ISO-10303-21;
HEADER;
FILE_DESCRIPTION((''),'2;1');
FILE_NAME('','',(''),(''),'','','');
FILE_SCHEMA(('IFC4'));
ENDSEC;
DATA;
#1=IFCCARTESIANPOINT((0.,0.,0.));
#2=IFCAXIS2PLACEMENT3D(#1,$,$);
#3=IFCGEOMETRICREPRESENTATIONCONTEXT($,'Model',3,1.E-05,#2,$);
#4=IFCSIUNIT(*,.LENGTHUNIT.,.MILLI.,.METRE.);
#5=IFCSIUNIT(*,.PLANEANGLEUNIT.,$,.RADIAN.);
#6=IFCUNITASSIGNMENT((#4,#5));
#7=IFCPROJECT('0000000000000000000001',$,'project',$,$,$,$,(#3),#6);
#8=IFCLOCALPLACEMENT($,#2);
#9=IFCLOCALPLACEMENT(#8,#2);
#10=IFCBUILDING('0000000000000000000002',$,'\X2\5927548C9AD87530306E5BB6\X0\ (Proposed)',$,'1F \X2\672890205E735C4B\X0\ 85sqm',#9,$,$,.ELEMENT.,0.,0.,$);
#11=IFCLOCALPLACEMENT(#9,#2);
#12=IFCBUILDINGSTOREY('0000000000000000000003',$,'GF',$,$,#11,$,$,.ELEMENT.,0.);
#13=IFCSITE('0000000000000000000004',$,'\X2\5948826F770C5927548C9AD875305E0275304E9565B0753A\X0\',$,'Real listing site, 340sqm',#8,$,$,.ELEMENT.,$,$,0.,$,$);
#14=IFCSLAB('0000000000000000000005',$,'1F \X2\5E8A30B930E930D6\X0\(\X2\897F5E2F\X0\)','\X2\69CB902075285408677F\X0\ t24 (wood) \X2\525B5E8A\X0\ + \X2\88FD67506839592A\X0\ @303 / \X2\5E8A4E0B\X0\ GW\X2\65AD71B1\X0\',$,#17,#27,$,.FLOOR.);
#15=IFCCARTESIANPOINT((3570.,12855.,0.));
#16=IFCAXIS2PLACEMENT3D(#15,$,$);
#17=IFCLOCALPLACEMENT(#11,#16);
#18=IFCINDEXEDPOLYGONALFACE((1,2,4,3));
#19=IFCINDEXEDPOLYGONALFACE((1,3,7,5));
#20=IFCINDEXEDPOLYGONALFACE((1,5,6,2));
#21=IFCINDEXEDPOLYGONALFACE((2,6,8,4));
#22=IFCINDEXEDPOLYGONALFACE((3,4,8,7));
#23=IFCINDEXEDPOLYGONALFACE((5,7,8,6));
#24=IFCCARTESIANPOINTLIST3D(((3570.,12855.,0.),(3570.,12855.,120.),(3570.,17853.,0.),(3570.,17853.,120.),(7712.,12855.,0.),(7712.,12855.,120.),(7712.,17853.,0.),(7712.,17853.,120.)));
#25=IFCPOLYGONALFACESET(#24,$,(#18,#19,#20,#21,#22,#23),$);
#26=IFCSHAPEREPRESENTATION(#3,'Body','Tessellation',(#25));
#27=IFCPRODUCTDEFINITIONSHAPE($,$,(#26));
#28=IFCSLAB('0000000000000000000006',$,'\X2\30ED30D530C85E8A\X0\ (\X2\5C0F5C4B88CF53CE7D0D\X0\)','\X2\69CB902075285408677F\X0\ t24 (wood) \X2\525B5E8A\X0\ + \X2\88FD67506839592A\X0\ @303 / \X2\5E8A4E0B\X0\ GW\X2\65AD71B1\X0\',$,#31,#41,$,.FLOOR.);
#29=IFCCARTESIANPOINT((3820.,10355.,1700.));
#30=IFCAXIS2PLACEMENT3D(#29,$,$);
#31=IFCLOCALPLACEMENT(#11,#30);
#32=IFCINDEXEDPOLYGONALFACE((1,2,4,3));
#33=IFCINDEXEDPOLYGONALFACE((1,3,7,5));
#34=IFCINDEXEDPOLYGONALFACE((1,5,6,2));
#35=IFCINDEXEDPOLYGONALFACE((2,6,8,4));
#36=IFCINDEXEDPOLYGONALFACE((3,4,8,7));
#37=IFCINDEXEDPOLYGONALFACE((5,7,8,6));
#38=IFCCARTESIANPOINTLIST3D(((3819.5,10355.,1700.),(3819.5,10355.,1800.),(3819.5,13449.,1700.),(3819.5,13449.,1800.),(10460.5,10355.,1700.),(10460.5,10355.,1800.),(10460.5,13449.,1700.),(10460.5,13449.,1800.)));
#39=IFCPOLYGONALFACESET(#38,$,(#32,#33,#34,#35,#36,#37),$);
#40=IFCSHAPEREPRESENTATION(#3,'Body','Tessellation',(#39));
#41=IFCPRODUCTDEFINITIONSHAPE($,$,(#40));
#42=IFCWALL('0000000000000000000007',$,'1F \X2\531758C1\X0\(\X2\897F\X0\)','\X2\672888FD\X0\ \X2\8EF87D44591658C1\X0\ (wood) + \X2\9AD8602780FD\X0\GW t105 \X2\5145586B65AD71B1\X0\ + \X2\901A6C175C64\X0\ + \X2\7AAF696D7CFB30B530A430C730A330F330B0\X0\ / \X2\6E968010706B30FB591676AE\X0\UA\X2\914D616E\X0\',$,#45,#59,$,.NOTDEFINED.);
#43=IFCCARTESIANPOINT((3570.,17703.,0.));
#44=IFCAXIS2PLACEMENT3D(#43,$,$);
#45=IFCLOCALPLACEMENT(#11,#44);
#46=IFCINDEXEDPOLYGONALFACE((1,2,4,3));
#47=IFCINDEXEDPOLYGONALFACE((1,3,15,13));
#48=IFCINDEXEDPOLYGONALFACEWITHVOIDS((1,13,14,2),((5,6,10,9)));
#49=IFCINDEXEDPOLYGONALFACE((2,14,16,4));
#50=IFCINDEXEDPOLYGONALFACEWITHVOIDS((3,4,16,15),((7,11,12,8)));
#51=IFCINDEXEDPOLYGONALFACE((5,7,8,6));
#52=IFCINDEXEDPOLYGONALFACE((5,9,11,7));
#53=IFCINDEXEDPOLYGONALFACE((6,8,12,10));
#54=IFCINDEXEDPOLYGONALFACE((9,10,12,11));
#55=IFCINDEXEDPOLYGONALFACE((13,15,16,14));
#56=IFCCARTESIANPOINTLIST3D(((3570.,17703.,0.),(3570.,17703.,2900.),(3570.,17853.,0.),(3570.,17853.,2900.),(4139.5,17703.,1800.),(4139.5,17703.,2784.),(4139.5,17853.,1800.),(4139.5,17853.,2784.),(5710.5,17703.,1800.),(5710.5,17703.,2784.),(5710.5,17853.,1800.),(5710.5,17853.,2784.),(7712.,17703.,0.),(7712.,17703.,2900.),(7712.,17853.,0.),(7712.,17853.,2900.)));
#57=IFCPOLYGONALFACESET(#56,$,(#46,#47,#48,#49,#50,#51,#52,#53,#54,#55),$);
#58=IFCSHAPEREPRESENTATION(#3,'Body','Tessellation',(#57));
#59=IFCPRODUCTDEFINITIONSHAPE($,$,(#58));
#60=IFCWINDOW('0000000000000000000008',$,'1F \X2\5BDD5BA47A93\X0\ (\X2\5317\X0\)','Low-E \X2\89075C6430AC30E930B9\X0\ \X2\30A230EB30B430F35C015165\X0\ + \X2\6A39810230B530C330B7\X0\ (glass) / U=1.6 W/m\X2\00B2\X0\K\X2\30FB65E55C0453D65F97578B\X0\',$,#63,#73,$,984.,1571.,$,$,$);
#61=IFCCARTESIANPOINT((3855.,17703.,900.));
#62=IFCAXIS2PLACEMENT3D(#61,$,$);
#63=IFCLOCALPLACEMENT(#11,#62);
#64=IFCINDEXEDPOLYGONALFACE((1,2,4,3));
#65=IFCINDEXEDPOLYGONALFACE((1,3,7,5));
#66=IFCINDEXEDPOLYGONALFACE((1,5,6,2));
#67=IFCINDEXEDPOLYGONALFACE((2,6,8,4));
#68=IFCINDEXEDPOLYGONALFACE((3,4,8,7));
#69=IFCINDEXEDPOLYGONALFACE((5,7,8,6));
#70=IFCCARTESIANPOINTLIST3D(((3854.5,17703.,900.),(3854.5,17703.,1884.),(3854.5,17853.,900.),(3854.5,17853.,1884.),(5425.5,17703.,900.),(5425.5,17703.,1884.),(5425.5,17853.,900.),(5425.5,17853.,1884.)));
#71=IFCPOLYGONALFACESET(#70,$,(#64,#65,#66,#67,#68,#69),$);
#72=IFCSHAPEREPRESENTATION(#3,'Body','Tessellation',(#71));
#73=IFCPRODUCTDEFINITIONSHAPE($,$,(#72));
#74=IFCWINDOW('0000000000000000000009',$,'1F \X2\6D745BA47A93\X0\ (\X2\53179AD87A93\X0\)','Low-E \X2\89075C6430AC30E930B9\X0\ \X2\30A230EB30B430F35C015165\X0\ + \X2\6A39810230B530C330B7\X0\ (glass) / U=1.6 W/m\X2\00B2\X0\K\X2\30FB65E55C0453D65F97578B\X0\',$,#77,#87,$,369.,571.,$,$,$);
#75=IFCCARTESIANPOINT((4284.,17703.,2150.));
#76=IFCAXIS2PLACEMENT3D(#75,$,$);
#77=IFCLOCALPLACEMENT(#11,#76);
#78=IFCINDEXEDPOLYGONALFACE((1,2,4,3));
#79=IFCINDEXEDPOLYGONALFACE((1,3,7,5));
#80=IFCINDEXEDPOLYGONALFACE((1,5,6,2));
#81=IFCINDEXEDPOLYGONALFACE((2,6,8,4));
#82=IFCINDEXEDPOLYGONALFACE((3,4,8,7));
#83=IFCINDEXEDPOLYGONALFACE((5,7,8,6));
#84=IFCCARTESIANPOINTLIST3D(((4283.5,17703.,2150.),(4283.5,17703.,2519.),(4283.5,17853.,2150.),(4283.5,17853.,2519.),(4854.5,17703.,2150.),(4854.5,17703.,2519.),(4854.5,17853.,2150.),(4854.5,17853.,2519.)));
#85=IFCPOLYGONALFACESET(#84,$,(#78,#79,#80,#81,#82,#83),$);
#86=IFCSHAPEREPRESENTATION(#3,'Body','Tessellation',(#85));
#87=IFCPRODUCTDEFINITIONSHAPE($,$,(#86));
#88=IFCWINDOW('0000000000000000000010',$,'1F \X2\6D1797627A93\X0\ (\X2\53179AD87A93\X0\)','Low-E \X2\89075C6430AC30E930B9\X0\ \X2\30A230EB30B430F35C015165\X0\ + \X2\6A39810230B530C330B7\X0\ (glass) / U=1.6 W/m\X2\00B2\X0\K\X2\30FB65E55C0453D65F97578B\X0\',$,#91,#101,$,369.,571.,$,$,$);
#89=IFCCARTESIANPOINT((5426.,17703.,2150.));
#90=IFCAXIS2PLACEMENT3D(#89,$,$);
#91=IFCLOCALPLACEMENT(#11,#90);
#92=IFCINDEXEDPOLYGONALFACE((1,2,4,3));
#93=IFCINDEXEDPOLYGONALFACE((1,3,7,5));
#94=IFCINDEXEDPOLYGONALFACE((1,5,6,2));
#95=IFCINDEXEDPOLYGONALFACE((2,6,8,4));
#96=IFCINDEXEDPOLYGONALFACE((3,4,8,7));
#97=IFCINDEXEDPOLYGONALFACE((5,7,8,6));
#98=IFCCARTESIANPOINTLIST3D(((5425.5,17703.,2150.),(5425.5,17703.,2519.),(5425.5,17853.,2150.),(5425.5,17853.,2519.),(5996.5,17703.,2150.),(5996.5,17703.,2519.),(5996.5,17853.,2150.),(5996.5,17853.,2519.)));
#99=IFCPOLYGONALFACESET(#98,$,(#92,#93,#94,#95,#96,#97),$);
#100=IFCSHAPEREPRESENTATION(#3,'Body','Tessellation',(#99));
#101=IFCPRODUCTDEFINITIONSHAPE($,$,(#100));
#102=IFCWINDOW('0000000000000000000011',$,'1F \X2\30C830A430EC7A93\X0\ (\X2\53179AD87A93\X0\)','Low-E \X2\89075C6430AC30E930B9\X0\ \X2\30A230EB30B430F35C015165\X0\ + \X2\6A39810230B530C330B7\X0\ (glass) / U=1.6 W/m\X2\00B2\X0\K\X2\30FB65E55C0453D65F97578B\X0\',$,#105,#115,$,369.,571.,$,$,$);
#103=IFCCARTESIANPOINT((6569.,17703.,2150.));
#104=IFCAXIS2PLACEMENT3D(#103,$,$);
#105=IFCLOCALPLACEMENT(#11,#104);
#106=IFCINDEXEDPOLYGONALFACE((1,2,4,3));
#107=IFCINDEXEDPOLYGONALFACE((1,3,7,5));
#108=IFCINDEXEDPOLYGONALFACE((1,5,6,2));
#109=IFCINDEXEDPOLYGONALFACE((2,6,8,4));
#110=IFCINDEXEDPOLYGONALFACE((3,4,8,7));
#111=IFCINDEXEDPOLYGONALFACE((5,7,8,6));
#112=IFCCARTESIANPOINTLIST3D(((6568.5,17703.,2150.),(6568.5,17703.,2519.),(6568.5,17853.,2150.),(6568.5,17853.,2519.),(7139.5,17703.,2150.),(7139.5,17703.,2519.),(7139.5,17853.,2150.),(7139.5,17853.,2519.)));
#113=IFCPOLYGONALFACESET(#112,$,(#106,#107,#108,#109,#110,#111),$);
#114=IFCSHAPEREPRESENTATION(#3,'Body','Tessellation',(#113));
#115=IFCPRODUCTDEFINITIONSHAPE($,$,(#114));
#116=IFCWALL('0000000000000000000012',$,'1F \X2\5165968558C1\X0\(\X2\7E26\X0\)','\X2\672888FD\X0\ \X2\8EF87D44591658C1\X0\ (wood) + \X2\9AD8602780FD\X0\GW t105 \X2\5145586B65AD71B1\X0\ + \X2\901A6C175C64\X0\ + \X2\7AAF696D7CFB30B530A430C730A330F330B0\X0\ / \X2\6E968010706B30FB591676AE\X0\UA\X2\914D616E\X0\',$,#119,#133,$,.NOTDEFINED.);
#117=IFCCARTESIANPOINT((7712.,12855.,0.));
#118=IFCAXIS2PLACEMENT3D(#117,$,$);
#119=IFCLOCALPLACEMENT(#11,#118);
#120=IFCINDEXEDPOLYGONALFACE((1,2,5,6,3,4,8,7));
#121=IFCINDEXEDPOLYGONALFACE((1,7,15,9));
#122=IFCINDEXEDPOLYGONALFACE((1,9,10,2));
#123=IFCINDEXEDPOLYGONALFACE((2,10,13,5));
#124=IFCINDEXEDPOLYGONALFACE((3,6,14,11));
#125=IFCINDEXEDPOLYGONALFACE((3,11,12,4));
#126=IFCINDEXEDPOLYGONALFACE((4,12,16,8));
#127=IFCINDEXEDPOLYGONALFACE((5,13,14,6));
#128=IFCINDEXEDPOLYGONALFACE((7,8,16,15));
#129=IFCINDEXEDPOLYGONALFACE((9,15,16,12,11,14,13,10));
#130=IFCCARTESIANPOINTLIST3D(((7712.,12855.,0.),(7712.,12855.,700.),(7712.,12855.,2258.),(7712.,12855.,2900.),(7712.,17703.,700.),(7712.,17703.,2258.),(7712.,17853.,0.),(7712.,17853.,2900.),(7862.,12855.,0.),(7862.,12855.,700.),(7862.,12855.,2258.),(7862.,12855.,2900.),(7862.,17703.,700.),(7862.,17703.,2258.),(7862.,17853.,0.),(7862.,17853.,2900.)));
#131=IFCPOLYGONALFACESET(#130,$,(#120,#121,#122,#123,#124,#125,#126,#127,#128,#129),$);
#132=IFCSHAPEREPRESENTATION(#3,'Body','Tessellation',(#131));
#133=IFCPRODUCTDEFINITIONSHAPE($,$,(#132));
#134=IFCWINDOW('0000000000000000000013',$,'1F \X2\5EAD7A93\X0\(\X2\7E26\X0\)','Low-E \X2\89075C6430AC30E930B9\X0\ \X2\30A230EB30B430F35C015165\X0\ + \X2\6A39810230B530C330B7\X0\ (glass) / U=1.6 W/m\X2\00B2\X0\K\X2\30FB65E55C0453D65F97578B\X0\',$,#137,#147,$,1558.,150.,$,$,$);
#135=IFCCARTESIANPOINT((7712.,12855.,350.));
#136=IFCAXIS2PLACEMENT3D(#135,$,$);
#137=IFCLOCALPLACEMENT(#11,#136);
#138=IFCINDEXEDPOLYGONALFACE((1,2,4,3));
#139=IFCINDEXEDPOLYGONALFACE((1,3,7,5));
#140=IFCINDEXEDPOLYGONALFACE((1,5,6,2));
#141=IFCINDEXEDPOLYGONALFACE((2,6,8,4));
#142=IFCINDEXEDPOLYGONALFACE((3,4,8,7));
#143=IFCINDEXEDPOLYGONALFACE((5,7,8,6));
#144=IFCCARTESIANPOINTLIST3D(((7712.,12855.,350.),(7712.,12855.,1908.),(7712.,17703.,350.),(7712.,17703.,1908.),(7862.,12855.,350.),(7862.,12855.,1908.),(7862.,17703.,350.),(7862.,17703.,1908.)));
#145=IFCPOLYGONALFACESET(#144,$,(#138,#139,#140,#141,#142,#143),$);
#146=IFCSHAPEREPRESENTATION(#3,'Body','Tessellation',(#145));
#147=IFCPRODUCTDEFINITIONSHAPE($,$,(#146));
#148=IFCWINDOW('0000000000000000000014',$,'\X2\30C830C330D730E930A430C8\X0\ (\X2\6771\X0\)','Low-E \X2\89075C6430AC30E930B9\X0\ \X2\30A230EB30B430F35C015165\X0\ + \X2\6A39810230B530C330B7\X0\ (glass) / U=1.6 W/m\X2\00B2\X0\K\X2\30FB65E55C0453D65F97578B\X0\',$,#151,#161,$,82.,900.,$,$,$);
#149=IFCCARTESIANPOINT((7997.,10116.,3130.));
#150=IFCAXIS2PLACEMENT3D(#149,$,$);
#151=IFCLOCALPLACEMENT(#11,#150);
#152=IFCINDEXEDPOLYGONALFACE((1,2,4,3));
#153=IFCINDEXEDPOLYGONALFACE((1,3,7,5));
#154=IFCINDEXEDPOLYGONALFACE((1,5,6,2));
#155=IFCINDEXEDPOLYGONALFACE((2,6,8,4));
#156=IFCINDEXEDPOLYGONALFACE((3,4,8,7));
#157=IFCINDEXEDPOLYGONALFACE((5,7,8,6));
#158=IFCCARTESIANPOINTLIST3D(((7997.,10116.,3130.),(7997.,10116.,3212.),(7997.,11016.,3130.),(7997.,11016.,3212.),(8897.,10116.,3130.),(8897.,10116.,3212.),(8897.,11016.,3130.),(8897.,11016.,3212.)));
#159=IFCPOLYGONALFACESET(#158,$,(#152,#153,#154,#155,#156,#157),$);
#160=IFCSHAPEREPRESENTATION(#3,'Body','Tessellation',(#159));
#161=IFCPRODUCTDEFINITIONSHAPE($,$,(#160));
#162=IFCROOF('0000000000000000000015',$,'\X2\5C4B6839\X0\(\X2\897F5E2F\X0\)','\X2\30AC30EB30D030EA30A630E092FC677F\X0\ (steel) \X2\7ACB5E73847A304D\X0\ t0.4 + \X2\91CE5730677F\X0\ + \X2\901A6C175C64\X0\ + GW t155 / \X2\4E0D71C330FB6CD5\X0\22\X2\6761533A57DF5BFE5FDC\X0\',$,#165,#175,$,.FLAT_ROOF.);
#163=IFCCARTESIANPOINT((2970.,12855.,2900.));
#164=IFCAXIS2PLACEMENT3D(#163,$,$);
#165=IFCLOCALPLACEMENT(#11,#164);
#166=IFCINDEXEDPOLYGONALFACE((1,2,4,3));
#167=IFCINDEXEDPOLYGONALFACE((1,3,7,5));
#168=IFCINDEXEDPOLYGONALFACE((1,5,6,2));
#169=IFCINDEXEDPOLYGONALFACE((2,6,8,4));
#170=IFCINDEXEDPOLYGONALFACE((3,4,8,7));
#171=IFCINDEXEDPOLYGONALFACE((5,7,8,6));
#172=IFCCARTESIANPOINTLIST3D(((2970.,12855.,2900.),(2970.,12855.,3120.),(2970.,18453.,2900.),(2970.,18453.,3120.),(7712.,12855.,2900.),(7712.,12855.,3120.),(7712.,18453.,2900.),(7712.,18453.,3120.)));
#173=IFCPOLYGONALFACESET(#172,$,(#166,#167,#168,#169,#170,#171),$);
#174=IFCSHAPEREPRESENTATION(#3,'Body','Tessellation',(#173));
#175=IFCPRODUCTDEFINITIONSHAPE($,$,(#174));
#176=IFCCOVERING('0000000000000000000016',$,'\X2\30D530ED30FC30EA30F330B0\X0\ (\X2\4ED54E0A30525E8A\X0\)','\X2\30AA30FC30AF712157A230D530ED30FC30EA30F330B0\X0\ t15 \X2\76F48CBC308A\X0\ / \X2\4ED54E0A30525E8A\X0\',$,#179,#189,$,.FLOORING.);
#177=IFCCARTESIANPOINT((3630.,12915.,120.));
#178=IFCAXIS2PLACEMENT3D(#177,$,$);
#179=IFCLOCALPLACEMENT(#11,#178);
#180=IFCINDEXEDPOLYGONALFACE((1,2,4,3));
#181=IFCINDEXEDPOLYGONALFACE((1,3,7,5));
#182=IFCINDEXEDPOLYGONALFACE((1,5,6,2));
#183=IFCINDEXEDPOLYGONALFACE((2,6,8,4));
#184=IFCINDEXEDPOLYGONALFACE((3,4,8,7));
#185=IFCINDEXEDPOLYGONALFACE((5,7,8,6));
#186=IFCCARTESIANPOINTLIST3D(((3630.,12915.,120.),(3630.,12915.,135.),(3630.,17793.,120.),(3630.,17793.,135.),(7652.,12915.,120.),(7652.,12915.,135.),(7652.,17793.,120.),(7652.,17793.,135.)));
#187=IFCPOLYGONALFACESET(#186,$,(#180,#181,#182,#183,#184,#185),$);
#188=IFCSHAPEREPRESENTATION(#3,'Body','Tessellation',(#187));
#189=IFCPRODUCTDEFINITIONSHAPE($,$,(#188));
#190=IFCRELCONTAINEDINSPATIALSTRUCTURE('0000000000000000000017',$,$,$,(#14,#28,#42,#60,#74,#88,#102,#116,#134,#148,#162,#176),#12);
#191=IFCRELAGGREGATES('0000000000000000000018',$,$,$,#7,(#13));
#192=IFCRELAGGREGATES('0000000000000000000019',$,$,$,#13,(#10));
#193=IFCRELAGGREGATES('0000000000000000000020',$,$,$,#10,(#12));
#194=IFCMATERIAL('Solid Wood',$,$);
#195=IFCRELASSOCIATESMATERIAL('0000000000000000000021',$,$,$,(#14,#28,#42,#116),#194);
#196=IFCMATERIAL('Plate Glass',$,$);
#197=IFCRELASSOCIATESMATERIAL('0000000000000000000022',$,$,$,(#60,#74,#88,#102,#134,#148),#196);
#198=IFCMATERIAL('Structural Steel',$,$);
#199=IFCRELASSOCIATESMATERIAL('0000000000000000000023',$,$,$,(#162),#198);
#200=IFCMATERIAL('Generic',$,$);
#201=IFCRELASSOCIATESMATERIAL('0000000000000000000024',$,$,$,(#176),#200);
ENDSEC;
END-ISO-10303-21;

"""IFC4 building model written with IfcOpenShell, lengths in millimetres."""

from ifc_helpers import new_model, si_unit, frame, frame_2d, origin, place, context, project, spatial, rectangle, extrude, material, element, fill, save


model = new_model("IFC4")

# Units and contexts
model_context = context("Model", 3, precision=1e-05, world=origin())
ifc_project = project(units=[si_unit("LENGTHUNIT", "METRE", prefix="MILLI"), si_unit("PLANEANGLEUNIT", "RADIAN")], contexts=[model_context])

# Site, building, storey
site_placement = place(None, origin())
site = spatial("IfcSite", under=ifc_project, at=site_placement, Name="奈良県大和高田市田井新町", ObjectType="Real listing site, 340sqm", CompositionType="ELEMENT", RefElevation=0.0)
building_placement = place(site_placement, origin())
building = spatial("IfcBuilding", under=site, at=building_placement, Name="大和高田の家 (Proposed)", ObjectType="1F 木造平屋 85sqm", CompositionType="ELEMENT", ElevationOfRefHeight=0.0, ElevationOfTerrain=0.0)
storey_placement = place(building_placement, origin())
storey = spatial("IfcBuildingStorey", under=building, at=storey_placement, Name="GF", CompositionType="ELEMENT", Elevation=0.0)

# Slabs
ifc_material_1 = material(Name="Solid Wood")
slab_1_placement = place(storey_placement, frame((3570.0, 12855.0, 0.0)))
element("IfcSlab", 1, at=slab_1_placement, inside=storey, material=ifc_material_1, Name="1F 床スラブ(西帯)", Description="構造用合板 t24 (wood) 剛床 + 製材根太 @303 / 床下 GW断熱", PredefinedType="FLOOR", context=model_context, shape_type="SweptSolid", body=[
    extrude(rectangle(XDim=4142.0, YDim=4998.0, at=frame_2d((2071.0, 2499.0))), frame((3570.0, 12855.0, 0.0)), (0.0, 0.0, 1.0), 120.0),
])
slab_2_placement = place(storey_placement, frame((3820.0, 10355.0, 1700.0)))
element("IfcSlab", 2, at=slab_2_placement, inside=storey, material=ifc_material_1, Name="ロフト床 (小屋裏収納)", Description="構造用合板 t24 (wood) 剛床 + 製材根太 @303 / 床下 GW断熱", PredefinedType="FLOOR", context=model_context, shape_type="SweptSolid", body=[
    extrude(rectangle(XDim=6641.0, YDim=3094.0, at=frame_2d((3320.0, 1547.0))), frame((3820.0, 10355.0, 1700.0)), (0.0, 0.0, 1.0), 100.0),
])

# Wall, openings, windows
wall_1_placement = place(storey_placement, frame((3570.0, 17703.0, 0.0)))
wall_1 = element("IfcWall", 3, at=wall_1_placement, inside=storey, material=ifc_material_1, Name="1F 北壁(西)", Description="木製 軸組外壁 (wood) + 高性能GW t105 充填断熱 + 通気層 + 窯業系サイディング / 準耐火・外皮UA配慮", PredefinedType="NOTDEFINED", context=model_context, shape_type="SweptSolid", body=[
    extrude(rectangle(XDim=4142.0, YDim=150.0, at=frame_2d((2071.0, 75.0))), frame((3570.0, 17703.0, 0.0)), (0.0, 0.0, 1.0), 2900.0),
])
opening_1_placement = place(storey_placement, frame((3855.0, 17703.0, 900.0)))
opening_1 = element("IfcOpeningElement", 4, at=opening_1_placement, cuts=wall_1, PredefinedType="NOTDEFINED", context=model_context, shape_type="SweptSolid", body=[
    extrude(rectangle(XDim=1571.0, YDim=150.0, at=frame_2d((785.0, 75.0))), frame((3855.0, 17703.0, 900.0)), (0.0, 0.0, 1.0), 984.0),
])
opening_2_placement = place(storey_placement, frame((4284.0, 17703.0, 2150.0)))
opening_2 = element("IfcOpeningElement", 5, at=opening_2_placement, cuts=wall_1, PredefinedType="NOTDEFINED", context=model_context, shape_type="SweptSolid", body=[
    extrude(rectangle(XDim=571.0, YDim=150.0, at=frame_2d((285.0, 75.0))), frame((4284.0, 17703.0, 2150.0)), (0.0, 0.0, 1.0), 369.0),
])
opening_3_placement = place(storey_placement, frame((5426.0, 17703.0, 2150.0)))
opening_3 = element("IfcOpeningElement", 6, at=opening_3_placement, cuts=wall_1, PredefinedType="NOTDEFINED", context=model_context, shape_type="SweptSolid", body=[
    extrude(rectangle(XDim=571.0, YDim=150.0, at=frame_2d((285.0, 75.0))), frame((5426.0, 17703.0, 2150.0)), (0.0, 0.0, 1.0), 369.0),
])
opening_4_placement = place(storey_placement, frame((6569.0, 17703.0, 2150.0)))
opening_4 = element("IfcOpeningElement", 7, at=opening_4_placement, cuts=wall_1, PredefinedType="NOTDEFINED", context=model_context, shape_type="SweptSolid", body=[
    extrude(rectangle(XDim=571.0, YDim=150.0, at=frame_2d((285.0, 75.0))), frame((6569.0, 17703.0, 2150.0)), (0.0, 0.0, 1.0), 369.0),
])
ifc_material_2 = material(Name="Plate Glass")
window_1_placement = place(storey_placement, frame((3855.0, 17703.0, 900.0)))
window_1 = element("IfcWindow", 8, at=window_1_placement, inside=storey, material=ifc_material_2, Name="1F 寝室窓 (北)", Description="Low-E 複層ガラス アルゴン封入 + 樹脂サッシ (glass) / U=1.6 W/m²K・日射取得型", OverallHeight=984.0, OverallWidth=1571.0, context=model_context, shape_type="SweptSolid", body=[
    extrude(rectangle(XDim=1571.0, YDim=150.0, at=frame_2d((785.0, 75.0))), frame((3855.0, 17703.0, 900.0)), (0.0, 0.0, 1.0), 984.0),
])
fill(opening_1, window_1)
window_2_placement = place(storey_placement, frame((4284.0, 17703.0, 2150.0)))
window_2 = element("IfcWindow", 9, at=window_2_placement, inside=storey, material=ifc_material_2, Name="1F 浴室窓 (北高窓)", Description="Low-E 複層ガラス アルゴン封入 + 樹脂サッシ (glass) / U=1.6 W/m²K・日射取得型", OverallHeight=369.0, OverallWidth=571.0, context=model_context, shape_type="SweptSolid", body=[
    extrude(rectangle(XDim=571.0, YDim=150.0, at=frame_2d((285.0, 75.0))), frame((4284.0, 17703.0, 2150.0)), (0.0, 0.0, 1.0), 369.0),
])
fill(opening_2, window_2)
window_3_placement = place(storey_placement, frame((5426.0, 17703.0, 2150.0)))
window_3 = element("IfcWindow", 10, at=window_3_placement, inside=storey, material=ifc_material_2, Name="1F 洗面窓 (北高窓)", Description="Low-E 複層ガラス アルゴン封入 + 樹脂サッシ (glass) / U=1.6 W/m²K・日射取得型", OverallHeight=369.0, OverallWidth=571.0, context=model_context, shape_type="SweptSolid", body=[
    extrude(rectangle(XDim=571.0, YDim=150.0, at=frame_2d((285.0, 75.0))), frame((5426.0, 17703.0, 2150.0)), (0.0, 0.0, 1.0), 369.0),
])
fill(opening_3, window_3)
window_4_placement = place(storey_placement, frame((6569.0, 17703.0, 2150.0)))
window_4 = element("IfcWindow", 11, at=window_4_placement, inside=storey, material=ifc_material_2, Name="1F トイレ窓 (北高窓)", Description="Low-E 複層ガラス アルゴン封入 + 樹脂サッシ (glass) / U=1.6 W/m²K・日射取得型", OverallHeight=369.0, OverallWidth=571.0, context=model_context, shape_type="SweptSolid", body=[
    extrude(rectangle(XDim=571.0, YDim=150.0, at=frame_2d((285.0, 75.0))), frame((6569.0, 17703.0, 2150.0)), (0.0, 0.0, 1.0), 369.0),
])
fill(opening_4, window_4)

# Wall, opening, window
wall_2_placement = place(storey_placement, frame((7712.0, 12855.0, 0.0)))
wall_2 = element("IfcWall", 12, at=wall_2_placement, inside=storey, material=ifc_material_1, Name="1F 入隅壁(縦)", Description="木製 軸組外壁 (wood) + 高性能GW t105 充填断熱 + 通気層 + 窯業系サイディング / 準耐火・外皮UA配慮", PredefinedType="NOTDEFINED", context=model_context, shape_type="SweptSolid", body=[
    extrude(rectangle(XDim=150.0, YDim=4998.0, at=frame_2d((75.0, 2499.0))), frame((7712.0, 12855.0, 0.0)), (0.0, 0.0, 1.0), 2900.0),
])
opening_5_placement = place(storey_placement, frame((7712.0, 12855.0, 350.0)))
opening_5 = element("IfcOpeningElement", 13, at=opening_5_placement, cuts=wall_2, PredefinedType="NOTDEFINED", context=model_context, shape_type="SweptSolid", body=[
    extrude(rectangle(XDim=150.0, YDim=4848.0, at=frame_2d((75.0, 2424.0))), frame((7712.0, 12855.0, 350.0)), (0.0, 0.0, 1.0), 1558.0),
])
window_5_placement = place(storey_placement, frame((7712.0, 12855.0, 350.0)))
window_5 = element("IfcWindow", 14, at=window_5_placement, inside=storey, material=ifc_material_2, Name="1F 庭窓(縦)", Description="Low-E 複層ガラス アルゴン封入 + 樹脂サッシ (glass) / U=1.6 W/m²K・日射取得型", OverallHeight=1558.0, OverallWidth=150.0, context=model_context, shape_type="SweptSolid", body=[
    extrude(rectangle(XDim=150.0, YDim=4848.0, at=frame_2d((75.0, 2424.0))), frame((7712.0, 12855.0, 350.0)), (0.0, 0.0, 1.0), 1558.0),
])
fill(opening_5, window_5)

# Window
window_6_placement = place(storey_placement, frame((7997.0, 10116.0, 3130.0)))
element("IfcWindow", 15, at=window_6_placement, inside=storey, material=ifc_material_2, Name="トップライト (東)", Description="Low-E 複層ガラス アルゴン封入 + 樹脂サッシ (glass) / U=1.6 W/m²K・日射取得型", OverallHeight=82.0, OverallWidth=900.0, context=model_context, shape_type="SweptSolid", body=[
    extrude(rectangle(XDim=900.0, YDim=900.0, at=frame_2d((450.0, 450.0))), frame((7997.0, 10116.0, 3130.0)), (0.0, 0.0, 1.0), 82.0),
])

# Roof
ifc_material_3 = material(Name="Structural Steel")
roof_placement = place(storey_placement, frame((2970.0, 12855.0, 2900.0)))
element("IfcRoof", 16, at=roof_placement, inside=storey, material=ifc_material_3, Name="屋根(西帯)", Description="ガルバリウム鋼板 (steel) 立平葺き t0.4 + 野地板 + 通気層 + GW t155 / 不燃・法22条区域対応", PredefinedType="FLAT_ROOF", context=model_context, shape_type="SweptSolid", body=[
    extrude(rectangle(XDim=4742.0, YDim=5598.0, at=frame_2d((2371.0, 2799.0))), frame((2970.0, 12855.0, 2900.0)), (0.0, 0.0, 1.0), 220.0),
])

# Covering
ifc_material_4 = material(Name="Generic")
covering_placement = place(storey_placement, frame((3630.0, 12915.0, 120.0)))
element("IfcCovering", 17, at=covering_placement, inside=storey, material=ifc_material_4, Name="フローリング (仕上げ床)", Description="オーク無垢フローリング t15 直貼り / 仕上げ床", PredefinedType="FLOORING", context=model_context, shape_type="SweptSolid", body=[
    extrude(rectangle(XDim=4022.0, YDim=4878.0, at=frame_2d((2011.0, 2439.0))), frame((3630.0, 12915.0, 120.0)), (0.0, 0.0, 1.0), 15.0),
])

save(model, "model.ifc")
